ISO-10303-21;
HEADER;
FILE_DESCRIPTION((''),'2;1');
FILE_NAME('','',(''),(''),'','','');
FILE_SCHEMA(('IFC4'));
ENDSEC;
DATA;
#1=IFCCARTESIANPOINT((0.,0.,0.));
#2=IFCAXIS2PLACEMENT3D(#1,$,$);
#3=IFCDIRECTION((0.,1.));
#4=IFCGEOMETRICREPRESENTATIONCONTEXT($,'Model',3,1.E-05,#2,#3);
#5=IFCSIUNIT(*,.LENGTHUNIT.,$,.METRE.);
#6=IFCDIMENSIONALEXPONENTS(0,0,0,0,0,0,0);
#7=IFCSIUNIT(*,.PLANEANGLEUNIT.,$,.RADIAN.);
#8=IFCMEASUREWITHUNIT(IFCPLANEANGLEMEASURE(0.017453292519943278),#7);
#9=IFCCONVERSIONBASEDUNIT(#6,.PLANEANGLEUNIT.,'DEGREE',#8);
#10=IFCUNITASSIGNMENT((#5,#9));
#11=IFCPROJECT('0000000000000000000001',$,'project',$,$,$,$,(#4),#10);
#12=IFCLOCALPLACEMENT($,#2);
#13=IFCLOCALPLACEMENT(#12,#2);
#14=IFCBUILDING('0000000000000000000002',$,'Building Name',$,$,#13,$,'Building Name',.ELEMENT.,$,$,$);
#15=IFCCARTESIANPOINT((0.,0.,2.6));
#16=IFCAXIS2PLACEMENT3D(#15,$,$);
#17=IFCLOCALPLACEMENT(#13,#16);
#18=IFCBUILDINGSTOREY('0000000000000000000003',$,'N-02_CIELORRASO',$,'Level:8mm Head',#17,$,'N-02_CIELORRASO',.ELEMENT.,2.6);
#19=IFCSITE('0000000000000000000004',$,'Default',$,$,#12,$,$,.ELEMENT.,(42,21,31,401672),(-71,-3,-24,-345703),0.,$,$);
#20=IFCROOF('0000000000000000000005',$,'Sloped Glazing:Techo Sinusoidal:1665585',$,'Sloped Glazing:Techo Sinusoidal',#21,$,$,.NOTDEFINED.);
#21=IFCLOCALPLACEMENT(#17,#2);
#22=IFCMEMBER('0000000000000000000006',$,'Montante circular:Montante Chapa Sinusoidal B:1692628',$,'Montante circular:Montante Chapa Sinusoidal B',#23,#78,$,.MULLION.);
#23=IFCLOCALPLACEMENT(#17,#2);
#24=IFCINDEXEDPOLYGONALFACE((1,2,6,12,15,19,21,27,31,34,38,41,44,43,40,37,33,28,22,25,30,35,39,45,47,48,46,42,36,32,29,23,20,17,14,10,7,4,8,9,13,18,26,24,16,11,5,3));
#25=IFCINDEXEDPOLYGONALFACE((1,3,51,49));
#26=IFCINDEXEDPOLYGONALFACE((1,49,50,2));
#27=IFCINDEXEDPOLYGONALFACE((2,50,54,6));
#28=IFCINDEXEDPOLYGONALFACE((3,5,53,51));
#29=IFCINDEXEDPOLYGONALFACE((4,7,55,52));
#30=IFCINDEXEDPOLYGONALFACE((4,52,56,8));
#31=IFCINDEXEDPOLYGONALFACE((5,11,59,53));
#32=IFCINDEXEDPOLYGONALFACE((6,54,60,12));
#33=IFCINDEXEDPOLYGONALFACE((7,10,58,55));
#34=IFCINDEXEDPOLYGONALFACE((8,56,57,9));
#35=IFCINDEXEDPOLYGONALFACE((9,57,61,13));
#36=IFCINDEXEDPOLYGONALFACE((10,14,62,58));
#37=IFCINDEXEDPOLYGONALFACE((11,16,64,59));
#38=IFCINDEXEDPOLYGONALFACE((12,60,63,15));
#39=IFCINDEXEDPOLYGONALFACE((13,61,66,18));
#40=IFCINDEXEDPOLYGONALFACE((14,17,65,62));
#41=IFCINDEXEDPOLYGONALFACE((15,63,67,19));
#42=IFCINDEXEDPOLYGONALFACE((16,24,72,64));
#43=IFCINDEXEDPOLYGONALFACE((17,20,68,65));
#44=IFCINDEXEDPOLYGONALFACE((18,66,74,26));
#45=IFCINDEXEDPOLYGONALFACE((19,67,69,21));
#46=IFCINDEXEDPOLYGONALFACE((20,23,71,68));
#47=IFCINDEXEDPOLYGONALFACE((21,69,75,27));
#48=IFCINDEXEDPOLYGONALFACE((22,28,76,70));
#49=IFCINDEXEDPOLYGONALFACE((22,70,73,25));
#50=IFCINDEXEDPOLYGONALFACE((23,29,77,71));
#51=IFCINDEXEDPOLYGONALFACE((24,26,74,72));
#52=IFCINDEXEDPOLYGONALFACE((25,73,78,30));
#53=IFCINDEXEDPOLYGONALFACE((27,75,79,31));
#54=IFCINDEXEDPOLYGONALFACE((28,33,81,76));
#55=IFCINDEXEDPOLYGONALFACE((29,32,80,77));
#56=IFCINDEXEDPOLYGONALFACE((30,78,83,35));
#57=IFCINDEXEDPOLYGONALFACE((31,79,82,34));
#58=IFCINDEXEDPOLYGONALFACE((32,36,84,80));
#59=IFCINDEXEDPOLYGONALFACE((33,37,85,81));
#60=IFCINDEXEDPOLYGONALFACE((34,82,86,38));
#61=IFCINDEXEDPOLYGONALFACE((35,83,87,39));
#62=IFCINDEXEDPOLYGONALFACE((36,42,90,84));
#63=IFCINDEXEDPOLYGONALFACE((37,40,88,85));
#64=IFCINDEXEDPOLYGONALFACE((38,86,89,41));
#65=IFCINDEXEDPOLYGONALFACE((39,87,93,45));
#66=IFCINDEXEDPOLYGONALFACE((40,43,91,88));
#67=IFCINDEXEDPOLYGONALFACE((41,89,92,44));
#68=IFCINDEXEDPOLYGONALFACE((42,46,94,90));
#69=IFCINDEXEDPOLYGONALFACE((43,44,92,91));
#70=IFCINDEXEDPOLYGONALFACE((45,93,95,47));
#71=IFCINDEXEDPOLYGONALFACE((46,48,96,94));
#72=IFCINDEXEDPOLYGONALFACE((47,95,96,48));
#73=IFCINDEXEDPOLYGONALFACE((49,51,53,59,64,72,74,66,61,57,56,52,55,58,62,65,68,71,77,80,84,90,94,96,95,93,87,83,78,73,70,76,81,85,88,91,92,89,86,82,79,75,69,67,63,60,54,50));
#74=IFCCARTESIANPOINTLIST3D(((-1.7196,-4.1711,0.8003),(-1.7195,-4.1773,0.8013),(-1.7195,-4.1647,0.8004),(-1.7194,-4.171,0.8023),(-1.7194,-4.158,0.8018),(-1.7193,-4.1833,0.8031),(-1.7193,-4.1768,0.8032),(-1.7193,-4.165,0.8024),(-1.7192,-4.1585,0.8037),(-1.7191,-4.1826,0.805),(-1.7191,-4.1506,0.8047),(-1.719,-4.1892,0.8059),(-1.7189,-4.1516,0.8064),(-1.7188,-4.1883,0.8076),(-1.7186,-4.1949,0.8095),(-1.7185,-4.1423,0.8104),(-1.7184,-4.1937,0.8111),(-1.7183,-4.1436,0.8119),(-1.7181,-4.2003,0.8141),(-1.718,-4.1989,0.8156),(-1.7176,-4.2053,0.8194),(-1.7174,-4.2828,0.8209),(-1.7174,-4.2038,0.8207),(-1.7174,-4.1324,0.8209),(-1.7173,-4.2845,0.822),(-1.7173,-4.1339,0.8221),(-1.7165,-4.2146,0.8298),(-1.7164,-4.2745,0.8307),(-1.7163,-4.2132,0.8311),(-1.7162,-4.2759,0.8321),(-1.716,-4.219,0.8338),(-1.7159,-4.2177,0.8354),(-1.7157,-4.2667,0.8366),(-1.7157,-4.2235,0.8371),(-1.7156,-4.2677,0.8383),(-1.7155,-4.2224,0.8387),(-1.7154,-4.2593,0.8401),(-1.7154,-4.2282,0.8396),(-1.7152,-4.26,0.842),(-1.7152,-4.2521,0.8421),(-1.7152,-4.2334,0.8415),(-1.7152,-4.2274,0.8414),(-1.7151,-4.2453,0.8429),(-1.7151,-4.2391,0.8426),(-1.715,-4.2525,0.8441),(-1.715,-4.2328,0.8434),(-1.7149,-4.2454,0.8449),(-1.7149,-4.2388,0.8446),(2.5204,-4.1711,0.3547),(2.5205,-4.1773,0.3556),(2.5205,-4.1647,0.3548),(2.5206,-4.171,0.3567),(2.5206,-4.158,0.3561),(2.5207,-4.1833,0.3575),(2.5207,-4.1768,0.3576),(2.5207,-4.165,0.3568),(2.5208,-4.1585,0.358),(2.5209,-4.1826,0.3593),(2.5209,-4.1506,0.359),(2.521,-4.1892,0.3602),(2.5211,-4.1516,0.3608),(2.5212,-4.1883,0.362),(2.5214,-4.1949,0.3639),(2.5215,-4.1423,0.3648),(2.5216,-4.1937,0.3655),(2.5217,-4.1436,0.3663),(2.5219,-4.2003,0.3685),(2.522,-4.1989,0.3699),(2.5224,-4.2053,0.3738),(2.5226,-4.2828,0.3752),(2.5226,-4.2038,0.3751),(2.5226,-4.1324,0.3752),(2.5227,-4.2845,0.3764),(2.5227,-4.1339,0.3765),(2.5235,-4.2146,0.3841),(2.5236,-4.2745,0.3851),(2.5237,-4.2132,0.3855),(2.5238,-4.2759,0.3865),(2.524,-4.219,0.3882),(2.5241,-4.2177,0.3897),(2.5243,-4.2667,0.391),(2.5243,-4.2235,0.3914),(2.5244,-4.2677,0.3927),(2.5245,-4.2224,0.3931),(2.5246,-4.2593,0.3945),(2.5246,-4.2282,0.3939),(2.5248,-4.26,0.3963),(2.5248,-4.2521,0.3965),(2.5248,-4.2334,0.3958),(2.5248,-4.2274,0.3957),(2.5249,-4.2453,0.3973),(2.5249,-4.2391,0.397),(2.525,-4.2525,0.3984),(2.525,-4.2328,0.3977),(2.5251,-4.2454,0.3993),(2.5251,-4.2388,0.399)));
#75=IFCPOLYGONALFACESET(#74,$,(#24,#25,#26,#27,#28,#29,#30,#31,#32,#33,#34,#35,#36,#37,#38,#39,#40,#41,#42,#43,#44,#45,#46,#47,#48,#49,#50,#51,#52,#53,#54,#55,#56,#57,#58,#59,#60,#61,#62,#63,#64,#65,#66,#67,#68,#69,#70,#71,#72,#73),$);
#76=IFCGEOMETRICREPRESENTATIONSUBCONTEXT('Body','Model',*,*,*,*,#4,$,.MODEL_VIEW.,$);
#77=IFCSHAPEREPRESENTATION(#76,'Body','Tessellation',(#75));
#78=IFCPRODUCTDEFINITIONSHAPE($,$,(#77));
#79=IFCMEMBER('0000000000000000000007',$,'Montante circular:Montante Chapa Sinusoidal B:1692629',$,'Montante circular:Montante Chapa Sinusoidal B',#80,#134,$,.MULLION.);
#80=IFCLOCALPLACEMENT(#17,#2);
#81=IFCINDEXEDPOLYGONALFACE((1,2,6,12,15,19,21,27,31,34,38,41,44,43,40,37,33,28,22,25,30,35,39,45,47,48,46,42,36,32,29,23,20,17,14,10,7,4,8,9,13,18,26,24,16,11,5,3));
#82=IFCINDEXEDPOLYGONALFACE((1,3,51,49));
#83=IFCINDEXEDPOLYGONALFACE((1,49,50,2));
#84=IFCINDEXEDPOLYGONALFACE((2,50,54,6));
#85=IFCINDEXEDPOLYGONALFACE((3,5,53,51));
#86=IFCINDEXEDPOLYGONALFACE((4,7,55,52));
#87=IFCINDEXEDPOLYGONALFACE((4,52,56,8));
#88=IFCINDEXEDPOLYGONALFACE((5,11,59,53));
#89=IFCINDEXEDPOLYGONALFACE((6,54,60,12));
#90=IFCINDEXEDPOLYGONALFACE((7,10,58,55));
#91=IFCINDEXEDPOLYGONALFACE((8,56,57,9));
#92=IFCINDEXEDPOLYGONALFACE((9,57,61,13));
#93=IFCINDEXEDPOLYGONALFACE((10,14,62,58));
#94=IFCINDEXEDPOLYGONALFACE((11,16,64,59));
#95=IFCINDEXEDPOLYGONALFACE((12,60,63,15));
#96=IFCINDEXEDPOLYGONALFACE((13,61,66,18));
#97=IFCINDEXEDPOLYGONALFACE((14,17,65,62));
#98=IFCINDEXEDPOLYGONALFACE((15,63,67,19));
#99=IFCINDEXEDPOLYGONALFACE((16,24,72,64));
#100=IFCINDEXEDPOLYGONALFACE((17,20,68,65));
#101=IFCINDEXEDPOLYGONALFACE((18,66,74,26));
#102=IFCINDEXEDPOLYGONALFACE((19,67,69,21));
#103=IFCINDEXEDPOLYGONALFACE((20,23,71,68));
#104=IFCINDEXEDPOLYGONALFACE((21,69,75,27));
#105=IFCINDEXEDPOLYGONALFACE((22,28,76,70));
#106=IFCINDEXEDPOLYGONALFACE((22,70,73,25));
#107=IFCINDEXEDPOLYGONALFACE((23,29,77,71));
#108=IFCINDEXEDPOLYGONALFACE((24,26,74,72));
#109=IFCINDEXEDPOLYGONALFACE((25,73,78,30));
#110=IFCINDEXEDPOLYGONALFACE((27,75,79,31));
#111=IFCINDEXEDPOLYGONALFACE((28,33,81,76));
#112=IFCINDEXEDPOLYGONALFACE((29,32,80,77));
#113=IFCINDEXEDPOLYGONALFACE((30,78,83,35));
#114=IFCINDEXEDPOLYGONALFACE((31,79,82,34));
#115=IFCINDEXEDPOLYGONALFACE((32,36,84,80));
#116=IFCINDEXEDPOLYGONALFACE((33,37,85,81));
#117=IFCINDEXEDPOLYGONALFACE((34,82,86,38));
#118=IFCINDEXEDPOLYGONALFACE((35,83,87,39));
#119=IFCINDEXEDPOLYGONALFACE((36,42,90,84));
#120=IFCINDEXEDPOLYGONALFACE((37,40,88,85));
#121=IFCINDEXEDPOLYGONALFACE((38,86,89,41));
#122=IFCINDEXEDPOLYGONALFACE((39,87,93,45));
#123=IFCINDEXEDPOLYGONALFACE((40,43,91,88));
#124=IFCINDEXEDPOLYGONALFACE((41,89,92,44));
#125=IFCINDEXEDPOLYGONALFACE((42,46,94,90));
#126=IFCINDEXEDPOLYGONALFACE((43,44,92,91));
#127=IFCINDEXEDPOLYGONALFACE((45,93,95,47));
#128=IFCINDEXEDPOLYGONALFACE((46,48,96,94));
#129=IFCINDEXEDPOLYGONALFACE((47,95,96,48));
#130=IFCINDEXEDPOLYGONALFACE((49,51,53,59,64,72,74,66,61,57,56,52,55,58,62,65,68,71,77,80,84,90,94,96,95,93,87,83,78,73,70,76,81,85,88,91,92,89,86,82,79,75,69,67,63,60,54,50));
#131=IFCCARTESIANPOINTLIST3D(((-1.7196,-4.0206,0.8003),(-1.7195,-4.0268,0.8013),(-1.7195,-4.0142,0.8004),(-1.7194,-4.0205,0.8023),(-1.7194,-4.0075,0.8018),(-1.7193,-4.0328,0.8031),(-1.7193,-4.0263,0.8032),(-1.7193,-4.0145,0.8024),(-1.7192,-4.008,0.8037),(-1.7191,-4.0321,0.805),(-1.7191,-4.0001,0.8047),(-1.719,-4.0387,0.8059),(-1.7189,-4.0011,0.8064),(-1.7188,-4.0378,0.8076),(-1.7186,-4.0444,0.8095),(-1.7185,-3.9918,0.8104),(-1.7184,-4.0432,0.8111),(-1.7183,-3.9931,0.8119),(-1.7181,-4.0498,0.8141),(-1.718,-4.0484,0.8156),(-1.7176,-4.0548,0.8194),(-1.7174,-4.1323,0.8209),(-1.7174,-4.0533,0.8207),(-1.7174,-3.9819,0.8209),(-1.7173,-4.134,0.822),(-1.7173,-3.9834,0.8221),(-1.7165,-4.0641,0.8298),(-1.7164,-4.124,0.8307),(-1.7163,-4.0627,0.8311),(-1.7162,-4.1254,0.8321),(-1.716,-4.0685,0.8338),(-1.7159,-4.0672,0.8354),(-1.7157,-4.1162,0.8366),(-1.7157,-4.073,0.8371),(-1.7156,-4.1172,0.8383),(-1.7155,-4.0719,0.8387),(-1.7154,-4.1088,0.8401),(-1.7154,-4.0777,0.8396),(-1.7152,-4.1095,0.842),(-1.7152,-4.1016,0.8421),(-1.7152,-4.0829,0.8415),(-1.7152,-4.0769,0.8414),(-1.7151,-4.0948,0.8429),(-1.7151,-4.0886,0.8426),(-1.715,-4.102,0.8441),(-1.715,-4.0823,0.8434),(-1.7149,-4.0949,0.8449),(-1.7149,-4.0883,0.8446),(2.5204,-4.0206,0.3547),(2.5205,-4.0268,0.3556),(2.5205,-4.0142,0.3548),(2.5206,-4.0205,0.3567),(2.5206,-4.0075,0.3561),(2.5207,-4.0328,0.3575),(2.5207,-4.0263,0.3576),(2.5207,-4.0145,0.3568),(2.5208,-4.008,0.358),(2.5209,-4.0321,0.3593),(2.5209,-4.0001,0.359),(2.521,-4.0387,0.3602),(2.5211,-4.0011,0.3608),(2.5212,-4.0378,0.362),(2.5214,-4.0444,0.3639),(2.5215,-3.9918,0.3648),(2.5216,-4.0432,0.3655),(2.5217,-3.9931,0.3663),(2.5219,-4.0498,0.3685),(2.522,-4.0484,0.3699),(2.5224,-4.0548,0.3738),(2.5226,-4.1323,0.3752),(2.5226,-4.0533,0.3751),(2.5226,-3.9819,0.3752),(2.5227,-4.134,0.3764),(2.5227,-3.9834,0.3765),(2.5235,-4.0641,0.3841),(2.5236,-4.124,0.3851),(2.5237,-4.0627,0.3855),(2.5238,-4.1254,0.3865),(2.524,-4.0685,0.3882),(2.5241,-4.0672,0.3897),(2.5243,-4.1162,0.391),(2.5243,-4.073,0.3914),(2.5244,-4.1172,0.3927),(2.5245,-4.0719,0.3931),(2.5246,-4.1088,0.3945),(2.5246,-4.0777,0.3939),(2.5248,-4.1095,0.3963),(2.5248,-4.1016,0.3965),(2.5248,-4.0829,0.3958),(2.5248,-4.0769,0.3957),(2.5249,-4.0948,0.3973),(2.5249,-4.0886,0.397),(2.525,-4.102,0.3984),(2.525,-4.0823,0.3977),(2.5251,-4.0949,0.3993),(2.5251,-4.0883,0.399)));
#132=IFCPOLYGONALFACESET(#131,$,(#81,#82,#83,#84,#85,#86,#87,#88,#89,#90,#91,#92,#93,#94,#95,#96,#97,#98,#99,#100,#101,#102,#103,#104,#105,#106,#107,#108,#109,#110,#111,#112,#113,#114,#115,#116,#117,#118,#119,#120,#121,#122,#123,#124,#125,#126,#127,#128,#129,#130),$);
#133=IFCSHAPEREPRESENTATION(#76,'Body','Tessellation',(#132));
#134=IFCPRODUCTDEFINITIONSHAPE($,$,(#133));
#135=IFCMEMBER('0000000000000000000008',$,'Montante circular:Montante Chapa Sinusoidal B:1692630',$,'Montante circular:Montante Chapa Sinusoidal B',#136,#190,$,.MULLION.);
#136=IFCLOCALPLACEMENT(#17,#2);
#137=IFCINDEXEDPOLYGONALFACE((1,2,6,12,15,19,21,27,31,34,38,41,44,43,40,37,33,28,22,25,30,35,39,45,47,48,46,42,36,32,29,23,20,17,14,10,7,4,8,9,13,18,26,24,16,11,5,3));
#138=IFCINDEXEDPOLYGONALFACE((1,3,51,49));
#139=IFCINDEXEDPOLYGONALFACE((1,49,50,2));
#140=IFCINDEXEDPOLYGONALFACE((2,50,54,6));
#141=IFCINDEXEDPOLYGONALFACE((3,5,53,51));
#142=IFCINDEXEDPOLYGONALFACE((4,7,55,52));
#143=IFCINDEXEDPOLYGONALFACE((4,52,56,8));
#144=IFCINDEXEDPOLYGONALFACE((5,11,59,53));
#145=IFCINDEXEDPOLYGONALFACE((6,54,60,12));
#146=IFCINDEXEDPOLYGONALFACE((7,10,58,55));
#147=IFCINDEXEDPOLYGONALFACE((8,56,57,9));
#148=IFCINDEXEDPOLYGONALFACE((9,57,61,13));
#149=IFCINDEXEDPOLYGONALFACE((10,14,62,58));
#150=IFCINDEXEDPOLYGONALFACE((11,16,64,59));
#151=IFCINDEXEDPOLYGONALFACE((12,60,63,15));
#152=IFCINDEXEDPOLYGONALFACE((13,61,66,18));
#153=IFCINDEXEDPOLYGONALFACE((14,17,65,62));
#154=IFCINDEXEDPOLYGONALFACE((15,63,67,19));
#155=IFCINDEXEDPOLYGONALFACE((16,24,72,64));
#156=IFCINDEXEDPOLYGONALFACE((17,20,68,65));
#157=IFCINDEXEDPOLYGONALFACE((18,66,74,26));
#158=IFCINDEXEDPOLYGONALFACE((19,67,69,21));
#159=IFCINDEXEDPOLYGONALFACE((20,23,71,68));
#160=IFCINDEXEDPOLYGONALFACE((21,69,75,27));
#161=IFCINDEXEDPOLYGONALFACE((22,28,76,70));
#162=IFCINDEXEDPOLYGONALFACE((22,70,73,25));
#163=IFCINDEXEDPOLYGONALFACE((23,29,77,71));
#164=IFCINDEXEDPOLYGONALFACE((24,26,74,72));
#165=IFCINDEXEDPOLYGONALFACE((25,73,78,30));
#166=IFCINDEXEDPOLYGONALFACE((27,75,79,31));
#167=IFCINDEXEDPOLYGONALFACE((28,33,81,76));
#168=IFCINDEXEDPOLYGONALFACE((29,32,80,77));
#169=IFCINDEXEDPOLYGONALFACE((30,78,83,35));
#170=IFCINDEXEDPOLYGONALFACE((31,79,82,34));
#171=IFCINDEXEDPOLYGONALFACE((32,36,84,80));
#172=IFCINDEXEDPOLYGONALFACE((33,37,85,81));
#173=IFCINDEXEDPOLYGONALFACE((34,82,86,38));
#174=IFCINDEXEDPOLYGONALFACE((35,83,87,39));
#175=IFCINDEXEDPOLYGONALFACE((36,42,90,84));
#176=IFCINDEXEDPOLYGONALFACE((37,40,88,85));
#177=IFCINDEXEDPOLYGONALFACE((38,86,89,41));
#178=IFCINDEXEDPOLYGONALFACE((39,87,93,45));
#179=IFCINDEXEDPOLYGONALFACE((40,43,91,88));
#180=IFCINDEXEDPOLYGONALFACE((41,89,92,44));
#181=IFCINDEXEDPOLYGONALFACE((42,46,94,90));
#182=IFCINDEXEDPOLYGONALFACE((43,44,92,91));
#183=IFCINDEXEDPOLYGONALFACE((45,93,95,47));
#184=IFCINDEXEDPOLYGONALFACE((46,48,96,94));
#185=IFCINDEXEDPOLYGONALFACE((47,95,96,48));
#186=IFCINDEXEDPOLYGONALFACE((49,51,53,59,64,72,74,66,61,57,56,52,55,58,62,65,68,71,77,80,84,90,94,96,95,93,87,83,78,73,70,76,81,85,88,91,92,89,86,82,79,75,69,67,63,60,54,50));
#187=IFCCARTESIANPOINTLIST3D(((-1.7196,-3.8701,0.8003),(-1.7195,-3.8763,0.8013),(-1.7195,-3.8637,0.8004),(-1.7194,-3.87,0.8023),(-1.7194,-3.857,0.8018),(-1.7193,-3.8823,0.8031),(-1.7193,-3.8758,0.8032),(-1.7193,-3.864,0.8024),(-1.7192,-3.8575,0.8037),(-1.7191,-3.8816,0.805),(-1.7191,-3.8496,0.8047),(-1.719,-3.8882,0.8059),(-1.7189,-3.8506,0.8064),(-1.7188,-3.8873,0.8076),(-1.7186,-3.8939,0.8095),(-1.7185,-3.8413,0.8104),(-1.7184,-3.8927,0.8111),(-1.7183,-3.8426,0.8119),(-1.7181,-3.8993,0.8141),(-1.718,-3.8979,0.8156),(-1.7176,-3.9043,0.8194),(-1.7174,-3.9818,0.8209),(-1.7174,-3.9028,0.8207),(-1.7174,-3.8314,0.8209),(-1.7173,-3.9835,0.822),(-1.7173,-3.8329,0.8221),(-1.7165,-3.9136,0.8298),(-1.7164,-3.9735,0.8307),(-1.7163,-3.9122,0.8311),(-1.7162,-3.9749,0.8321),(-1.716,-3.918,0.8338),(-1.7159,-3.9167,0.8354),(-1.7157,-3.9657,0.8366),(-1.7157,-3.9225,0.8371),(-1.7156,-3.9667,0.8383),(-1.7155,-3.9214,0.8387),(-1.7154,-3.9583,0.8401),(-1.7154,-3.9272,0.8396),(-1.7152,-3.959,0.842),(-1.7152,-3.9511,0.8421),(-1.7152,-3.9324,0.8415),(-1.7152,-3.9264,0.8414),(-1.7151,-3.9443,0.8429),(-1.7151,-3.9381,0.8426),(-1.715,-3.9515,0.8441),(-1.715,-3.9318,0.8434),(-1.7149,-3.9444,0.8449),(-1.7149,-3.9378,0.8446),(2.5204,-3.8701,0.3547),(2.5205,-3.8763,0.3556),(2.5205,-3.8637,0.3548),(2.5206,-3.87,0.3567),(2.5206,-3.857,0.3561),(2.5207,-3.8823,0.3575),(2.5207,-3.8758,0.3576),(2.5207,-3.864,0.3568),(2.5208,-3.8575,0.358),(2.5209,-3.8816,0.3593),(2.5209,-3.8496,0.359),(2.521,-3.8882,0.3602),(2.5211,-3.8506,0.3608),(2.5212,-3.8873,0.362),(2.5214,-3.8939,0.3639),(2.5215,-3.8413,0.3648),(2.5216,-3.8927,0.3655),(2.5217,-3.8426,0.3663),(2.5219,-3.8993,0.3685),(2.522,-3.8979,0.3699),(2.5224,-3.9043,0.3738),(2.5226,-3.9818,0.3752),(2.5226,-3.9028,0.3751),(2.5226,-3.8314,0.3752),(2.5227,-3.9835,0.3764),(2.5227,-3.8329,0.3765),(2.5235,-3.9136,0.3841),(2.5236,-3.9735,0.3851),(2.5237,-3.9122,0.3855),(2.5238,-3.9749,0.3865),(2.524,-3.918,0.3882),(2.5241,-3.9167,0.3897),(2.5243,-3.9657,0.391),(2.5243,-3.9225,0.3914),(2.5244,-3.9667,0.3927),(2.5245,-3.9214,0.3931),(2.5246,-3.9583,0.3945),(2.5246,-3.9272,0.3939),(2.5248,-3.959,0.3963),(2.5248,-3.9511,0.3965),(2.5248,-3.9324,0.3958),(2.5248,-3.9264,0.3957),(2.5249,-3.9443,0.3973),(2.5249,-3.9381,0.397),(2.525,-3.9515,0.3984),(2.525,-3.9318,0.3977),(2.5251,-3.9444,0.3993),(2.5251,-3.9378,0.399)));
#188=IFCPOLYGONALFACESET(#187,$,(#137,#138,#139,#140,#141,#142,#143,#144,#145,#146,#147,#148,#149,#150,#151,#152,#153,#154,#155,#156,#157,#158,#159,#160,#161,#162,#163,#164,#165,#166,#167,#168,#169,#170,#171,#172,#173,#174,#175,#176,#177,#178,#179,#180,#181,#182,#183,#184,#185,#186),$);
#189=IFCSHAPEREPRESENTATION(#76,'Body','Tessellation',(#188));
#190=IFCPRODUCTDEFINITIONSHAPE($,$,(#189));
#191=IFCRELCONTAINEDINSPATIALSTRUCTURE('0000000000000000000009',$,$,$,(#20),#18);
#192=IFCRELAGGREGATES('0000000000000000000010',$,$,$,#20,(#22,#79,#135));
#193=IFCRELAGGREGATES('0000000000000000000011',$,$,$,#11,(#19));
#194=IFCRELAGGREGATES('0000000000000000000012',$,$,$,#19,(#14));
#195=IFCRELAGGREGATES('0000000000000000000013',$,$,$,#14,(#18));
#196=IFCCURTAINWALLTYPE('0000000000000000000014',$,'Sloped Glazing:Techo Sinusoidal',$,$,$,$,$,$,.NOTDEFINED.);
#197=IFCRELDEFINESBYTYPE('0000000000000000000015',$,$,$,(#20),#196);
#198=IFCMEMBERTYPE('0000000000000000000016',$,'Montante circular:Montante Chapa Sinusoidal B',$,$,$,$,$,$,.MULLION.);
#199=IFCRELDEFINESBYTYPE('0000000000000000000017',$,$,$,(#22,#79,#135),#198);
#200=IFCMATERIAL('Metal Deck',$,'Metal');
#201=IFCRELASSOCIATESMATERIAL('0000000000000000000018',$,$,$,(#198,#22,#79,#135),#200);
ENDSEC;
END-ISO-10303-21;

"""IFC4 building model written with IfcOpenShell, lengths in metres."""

from ifc_helpers import new_model, entity, si_unit, converted_unit, direction, frame, origin, place, context, subcontext, project, spatial, indexed_curve, outline, extrude, source, transform, mapped, material, type_object, type_shapes, element, aggregate, save


model = new_model("IFC4")

# Units and contexts
model_context = context("Model", 3, precision=1e-05, world=origin(), true_north=direction((0.0, 1.0)))
body_context = subcontext(model_context, "Body", "Model", "MODEL_VIEW")
ifc_project = project(units=[si_unit("LENGTHUNIT", "METRE"), converted_unit("PLANEANGLEUNIT", "DEGREE", entity("IfcPlaneAngleMeasure", 0.017453292519943278), si_unit("PLANEANGLEUNIT", "RADIAN"), dimensions=[0, 0, 0, 0, 0, 0, 0])], contexts=[model_context])

# Site, building, storey
site_placement = place(None, origin())
site = spatial("IfcSite", under=ifc_project, at=site_placement, Name="Default", CompositionType="ELEMENT", RefLatitude=(42, 21, 31, 401672), RefLongitude=(-71, -3, -24, -345703), RefElevation=0.0)
building_placement = place(site_placement, origin())
building = spatial("IfcBuilding", under=site, at=building_placement, Name="Building Name", LongName="Building Name", CompositionType="ELEMENT")
storey_placement = place(building_placement, frame((0.0, 0.0, 2.6)))
storey = spatial("IfcBuildingStorey", under=building, at=storey_placement, Name="N-02_CIELORRASO", ObjectType="Level:8mm Head", LongName="N-02_CIELORRASO", CompositionType="ELEMENT", Elevation=2.6)

# Roof, members
curtain_wall_type = type_object("IfcCurtainWallType", Name="Sloped Glazing:Techo Sinusoidal", PredefinedType="NOTDEFINED")
roof_1_placement = place(storey_placement, frame((0.0, 0.0, -2.6)))
roof_1 = element("IfcRoof", 1, at=roof_1_placement, inside=storey, type_object=curtain_wall_type, Name="Sloped Glazing:Techo Sinusoidal:1665585", ObjectType="Sloped Glazing:Techo Sinusoidal", PredefinedType="NOTDEFINED")
ifc_material = material(Name="Metal Deck", Category="Metal")
member_type_1 = type_object("IfcMemberType", Name="Montante circular:Montante Chapa Sinusoidal B", PredefinedType="MULLION", material=ifc_material)
shared_shape_1 = source(origin(), body_context, "Body", "SweptSolid", [
    extrude(outline(indexed_curve([(0.0595, -0.0443), (0.0615, -0.0443), (0.0603, -0.031), (0.0572, -0.0213), (0.053, -0.0138), (0.0481, -0.0078), (0.0427, -0.003), (0.0372, 0.0005), (0.0315, 0.0029), (0.0259, 0.0044), (0.0203, 0.0051), (0.0146, 0.005), (0.0084, 0.0041), (-0.0053, 0.0009), (-0.0123, -0.0005), (-0.0191, -0.0012), (-0.0256, -0.001), (-0.0317, 0.0001), (-0.0375, 0.0019), (-0.0428, 0.0046), (-0.0477, 0.0081), (-0.0522, 0.0128), (-0.0563, 0.0191), (-0.0597, 0.0282), (-0.0617, 0.0421), (-0.0637, 0.042), (-0.0616, 0.0277), (-0.0581, 0.0182), (-0.0537, 0.0116), (-0.049, 0.0066), (-0.0438, 0.0028), (-0.0382, 0.0001), (-0.0322, -0.0019), (-0.0258, -0.003), (-0.019, -0.0032), (-0.012, -0.0025), (-0.0048, -0.0011), (0.0088, 0.0021), (0.0147, 0.003), (0.0202, 0.0031), (0.0255, 0.0024), (0.0309, 0.001), (0.0362, -0.0013), (0.0415, -0.0046), (0.0466, -0.0092), (0.0513, -0.0149), (0.0554, -0.0221), (0.0584, -0.0314), (0.0595, -0.0443)], self_intersect=False)), frame((-0.007, 0.0228, -4.2634), z_axis=(0.0, 0.0, 1.0), x_axis=(-0.819152, -0.573576, 0.0)), (0.0, 0.0, 1.0), 4.2634),
])
type_shapes(member_type_1, [shared_shape_1])
member_1_placement = place(roof_1_placement, frame((-1.7148, -4.2016, 3.4456), z_axis=(-0.994522, 0.0, 0.104528), x_axis=(0.0, 1.0, 0.0)))
member_1 = element("IfcMember", 2, at=member_1_placement, type_object=member_type_1, material=ifc_material, Name="Montante circular:Montante Chapa Sinusoidal B:1692628", ObjectType="Montante circular:Montante Chapa Sinusoidal B", PredefinedType="MULLION", context=body_context, shape_type="MappedRepresentation", body=[
    mapped(shared_shape_1, transform((0.0, 0.0, 0.0), scale=1.0)),
])
member_2_placement = place(roof_1_placement, frame((-1.7148, -4.0511, 3.4456), z_axis=(-0.994522, 0.0, 0.104528), x_axis=(0.0, 1.0, 0.0)))
member_2 = element("IfcMember", 3, at=member_2_placement, type_object=member_type_1, material=ifc_material, Name="Montante circular:Montante Chapa Sinusoidal B:1692629", ObjectType="Montante circular:Montante Chapa Sinusoidal B", PredefinedType="MULLION", context=body_context, shape_type="MappedRepresentation", body=[
    mapped(shared_shape_1, transform((0.0, 0.0, 0.0), scale=1.0)),
])
member_3_placement = place(roof_1_placement, frame((-1.7148, -3.9006, 3.4456), z_axis=(-0.994522, 0.0, 0.104528), x_axis=(0.0, 1.0, 0.0)))
member_3 = element("IfcMember", 4, at=member_3_placement, type_object=member_type_1, material=ifc_material, Name="Montante circular:Montante Chapa Sinusoidal B:1692630", ObjectType="Montante circular:Montante Chapa Sinusoidal B", PredefinedType="MULLION", context=body_context, shape_type="MappedRepresentation", body=[
    mapped(shared_shape_1, transform((0.0, 0.0, 0.0), scale=1.0)),
])
aggregate(roof_1, [member_1, member_2, member_3])

save(model, "model.ifc")
